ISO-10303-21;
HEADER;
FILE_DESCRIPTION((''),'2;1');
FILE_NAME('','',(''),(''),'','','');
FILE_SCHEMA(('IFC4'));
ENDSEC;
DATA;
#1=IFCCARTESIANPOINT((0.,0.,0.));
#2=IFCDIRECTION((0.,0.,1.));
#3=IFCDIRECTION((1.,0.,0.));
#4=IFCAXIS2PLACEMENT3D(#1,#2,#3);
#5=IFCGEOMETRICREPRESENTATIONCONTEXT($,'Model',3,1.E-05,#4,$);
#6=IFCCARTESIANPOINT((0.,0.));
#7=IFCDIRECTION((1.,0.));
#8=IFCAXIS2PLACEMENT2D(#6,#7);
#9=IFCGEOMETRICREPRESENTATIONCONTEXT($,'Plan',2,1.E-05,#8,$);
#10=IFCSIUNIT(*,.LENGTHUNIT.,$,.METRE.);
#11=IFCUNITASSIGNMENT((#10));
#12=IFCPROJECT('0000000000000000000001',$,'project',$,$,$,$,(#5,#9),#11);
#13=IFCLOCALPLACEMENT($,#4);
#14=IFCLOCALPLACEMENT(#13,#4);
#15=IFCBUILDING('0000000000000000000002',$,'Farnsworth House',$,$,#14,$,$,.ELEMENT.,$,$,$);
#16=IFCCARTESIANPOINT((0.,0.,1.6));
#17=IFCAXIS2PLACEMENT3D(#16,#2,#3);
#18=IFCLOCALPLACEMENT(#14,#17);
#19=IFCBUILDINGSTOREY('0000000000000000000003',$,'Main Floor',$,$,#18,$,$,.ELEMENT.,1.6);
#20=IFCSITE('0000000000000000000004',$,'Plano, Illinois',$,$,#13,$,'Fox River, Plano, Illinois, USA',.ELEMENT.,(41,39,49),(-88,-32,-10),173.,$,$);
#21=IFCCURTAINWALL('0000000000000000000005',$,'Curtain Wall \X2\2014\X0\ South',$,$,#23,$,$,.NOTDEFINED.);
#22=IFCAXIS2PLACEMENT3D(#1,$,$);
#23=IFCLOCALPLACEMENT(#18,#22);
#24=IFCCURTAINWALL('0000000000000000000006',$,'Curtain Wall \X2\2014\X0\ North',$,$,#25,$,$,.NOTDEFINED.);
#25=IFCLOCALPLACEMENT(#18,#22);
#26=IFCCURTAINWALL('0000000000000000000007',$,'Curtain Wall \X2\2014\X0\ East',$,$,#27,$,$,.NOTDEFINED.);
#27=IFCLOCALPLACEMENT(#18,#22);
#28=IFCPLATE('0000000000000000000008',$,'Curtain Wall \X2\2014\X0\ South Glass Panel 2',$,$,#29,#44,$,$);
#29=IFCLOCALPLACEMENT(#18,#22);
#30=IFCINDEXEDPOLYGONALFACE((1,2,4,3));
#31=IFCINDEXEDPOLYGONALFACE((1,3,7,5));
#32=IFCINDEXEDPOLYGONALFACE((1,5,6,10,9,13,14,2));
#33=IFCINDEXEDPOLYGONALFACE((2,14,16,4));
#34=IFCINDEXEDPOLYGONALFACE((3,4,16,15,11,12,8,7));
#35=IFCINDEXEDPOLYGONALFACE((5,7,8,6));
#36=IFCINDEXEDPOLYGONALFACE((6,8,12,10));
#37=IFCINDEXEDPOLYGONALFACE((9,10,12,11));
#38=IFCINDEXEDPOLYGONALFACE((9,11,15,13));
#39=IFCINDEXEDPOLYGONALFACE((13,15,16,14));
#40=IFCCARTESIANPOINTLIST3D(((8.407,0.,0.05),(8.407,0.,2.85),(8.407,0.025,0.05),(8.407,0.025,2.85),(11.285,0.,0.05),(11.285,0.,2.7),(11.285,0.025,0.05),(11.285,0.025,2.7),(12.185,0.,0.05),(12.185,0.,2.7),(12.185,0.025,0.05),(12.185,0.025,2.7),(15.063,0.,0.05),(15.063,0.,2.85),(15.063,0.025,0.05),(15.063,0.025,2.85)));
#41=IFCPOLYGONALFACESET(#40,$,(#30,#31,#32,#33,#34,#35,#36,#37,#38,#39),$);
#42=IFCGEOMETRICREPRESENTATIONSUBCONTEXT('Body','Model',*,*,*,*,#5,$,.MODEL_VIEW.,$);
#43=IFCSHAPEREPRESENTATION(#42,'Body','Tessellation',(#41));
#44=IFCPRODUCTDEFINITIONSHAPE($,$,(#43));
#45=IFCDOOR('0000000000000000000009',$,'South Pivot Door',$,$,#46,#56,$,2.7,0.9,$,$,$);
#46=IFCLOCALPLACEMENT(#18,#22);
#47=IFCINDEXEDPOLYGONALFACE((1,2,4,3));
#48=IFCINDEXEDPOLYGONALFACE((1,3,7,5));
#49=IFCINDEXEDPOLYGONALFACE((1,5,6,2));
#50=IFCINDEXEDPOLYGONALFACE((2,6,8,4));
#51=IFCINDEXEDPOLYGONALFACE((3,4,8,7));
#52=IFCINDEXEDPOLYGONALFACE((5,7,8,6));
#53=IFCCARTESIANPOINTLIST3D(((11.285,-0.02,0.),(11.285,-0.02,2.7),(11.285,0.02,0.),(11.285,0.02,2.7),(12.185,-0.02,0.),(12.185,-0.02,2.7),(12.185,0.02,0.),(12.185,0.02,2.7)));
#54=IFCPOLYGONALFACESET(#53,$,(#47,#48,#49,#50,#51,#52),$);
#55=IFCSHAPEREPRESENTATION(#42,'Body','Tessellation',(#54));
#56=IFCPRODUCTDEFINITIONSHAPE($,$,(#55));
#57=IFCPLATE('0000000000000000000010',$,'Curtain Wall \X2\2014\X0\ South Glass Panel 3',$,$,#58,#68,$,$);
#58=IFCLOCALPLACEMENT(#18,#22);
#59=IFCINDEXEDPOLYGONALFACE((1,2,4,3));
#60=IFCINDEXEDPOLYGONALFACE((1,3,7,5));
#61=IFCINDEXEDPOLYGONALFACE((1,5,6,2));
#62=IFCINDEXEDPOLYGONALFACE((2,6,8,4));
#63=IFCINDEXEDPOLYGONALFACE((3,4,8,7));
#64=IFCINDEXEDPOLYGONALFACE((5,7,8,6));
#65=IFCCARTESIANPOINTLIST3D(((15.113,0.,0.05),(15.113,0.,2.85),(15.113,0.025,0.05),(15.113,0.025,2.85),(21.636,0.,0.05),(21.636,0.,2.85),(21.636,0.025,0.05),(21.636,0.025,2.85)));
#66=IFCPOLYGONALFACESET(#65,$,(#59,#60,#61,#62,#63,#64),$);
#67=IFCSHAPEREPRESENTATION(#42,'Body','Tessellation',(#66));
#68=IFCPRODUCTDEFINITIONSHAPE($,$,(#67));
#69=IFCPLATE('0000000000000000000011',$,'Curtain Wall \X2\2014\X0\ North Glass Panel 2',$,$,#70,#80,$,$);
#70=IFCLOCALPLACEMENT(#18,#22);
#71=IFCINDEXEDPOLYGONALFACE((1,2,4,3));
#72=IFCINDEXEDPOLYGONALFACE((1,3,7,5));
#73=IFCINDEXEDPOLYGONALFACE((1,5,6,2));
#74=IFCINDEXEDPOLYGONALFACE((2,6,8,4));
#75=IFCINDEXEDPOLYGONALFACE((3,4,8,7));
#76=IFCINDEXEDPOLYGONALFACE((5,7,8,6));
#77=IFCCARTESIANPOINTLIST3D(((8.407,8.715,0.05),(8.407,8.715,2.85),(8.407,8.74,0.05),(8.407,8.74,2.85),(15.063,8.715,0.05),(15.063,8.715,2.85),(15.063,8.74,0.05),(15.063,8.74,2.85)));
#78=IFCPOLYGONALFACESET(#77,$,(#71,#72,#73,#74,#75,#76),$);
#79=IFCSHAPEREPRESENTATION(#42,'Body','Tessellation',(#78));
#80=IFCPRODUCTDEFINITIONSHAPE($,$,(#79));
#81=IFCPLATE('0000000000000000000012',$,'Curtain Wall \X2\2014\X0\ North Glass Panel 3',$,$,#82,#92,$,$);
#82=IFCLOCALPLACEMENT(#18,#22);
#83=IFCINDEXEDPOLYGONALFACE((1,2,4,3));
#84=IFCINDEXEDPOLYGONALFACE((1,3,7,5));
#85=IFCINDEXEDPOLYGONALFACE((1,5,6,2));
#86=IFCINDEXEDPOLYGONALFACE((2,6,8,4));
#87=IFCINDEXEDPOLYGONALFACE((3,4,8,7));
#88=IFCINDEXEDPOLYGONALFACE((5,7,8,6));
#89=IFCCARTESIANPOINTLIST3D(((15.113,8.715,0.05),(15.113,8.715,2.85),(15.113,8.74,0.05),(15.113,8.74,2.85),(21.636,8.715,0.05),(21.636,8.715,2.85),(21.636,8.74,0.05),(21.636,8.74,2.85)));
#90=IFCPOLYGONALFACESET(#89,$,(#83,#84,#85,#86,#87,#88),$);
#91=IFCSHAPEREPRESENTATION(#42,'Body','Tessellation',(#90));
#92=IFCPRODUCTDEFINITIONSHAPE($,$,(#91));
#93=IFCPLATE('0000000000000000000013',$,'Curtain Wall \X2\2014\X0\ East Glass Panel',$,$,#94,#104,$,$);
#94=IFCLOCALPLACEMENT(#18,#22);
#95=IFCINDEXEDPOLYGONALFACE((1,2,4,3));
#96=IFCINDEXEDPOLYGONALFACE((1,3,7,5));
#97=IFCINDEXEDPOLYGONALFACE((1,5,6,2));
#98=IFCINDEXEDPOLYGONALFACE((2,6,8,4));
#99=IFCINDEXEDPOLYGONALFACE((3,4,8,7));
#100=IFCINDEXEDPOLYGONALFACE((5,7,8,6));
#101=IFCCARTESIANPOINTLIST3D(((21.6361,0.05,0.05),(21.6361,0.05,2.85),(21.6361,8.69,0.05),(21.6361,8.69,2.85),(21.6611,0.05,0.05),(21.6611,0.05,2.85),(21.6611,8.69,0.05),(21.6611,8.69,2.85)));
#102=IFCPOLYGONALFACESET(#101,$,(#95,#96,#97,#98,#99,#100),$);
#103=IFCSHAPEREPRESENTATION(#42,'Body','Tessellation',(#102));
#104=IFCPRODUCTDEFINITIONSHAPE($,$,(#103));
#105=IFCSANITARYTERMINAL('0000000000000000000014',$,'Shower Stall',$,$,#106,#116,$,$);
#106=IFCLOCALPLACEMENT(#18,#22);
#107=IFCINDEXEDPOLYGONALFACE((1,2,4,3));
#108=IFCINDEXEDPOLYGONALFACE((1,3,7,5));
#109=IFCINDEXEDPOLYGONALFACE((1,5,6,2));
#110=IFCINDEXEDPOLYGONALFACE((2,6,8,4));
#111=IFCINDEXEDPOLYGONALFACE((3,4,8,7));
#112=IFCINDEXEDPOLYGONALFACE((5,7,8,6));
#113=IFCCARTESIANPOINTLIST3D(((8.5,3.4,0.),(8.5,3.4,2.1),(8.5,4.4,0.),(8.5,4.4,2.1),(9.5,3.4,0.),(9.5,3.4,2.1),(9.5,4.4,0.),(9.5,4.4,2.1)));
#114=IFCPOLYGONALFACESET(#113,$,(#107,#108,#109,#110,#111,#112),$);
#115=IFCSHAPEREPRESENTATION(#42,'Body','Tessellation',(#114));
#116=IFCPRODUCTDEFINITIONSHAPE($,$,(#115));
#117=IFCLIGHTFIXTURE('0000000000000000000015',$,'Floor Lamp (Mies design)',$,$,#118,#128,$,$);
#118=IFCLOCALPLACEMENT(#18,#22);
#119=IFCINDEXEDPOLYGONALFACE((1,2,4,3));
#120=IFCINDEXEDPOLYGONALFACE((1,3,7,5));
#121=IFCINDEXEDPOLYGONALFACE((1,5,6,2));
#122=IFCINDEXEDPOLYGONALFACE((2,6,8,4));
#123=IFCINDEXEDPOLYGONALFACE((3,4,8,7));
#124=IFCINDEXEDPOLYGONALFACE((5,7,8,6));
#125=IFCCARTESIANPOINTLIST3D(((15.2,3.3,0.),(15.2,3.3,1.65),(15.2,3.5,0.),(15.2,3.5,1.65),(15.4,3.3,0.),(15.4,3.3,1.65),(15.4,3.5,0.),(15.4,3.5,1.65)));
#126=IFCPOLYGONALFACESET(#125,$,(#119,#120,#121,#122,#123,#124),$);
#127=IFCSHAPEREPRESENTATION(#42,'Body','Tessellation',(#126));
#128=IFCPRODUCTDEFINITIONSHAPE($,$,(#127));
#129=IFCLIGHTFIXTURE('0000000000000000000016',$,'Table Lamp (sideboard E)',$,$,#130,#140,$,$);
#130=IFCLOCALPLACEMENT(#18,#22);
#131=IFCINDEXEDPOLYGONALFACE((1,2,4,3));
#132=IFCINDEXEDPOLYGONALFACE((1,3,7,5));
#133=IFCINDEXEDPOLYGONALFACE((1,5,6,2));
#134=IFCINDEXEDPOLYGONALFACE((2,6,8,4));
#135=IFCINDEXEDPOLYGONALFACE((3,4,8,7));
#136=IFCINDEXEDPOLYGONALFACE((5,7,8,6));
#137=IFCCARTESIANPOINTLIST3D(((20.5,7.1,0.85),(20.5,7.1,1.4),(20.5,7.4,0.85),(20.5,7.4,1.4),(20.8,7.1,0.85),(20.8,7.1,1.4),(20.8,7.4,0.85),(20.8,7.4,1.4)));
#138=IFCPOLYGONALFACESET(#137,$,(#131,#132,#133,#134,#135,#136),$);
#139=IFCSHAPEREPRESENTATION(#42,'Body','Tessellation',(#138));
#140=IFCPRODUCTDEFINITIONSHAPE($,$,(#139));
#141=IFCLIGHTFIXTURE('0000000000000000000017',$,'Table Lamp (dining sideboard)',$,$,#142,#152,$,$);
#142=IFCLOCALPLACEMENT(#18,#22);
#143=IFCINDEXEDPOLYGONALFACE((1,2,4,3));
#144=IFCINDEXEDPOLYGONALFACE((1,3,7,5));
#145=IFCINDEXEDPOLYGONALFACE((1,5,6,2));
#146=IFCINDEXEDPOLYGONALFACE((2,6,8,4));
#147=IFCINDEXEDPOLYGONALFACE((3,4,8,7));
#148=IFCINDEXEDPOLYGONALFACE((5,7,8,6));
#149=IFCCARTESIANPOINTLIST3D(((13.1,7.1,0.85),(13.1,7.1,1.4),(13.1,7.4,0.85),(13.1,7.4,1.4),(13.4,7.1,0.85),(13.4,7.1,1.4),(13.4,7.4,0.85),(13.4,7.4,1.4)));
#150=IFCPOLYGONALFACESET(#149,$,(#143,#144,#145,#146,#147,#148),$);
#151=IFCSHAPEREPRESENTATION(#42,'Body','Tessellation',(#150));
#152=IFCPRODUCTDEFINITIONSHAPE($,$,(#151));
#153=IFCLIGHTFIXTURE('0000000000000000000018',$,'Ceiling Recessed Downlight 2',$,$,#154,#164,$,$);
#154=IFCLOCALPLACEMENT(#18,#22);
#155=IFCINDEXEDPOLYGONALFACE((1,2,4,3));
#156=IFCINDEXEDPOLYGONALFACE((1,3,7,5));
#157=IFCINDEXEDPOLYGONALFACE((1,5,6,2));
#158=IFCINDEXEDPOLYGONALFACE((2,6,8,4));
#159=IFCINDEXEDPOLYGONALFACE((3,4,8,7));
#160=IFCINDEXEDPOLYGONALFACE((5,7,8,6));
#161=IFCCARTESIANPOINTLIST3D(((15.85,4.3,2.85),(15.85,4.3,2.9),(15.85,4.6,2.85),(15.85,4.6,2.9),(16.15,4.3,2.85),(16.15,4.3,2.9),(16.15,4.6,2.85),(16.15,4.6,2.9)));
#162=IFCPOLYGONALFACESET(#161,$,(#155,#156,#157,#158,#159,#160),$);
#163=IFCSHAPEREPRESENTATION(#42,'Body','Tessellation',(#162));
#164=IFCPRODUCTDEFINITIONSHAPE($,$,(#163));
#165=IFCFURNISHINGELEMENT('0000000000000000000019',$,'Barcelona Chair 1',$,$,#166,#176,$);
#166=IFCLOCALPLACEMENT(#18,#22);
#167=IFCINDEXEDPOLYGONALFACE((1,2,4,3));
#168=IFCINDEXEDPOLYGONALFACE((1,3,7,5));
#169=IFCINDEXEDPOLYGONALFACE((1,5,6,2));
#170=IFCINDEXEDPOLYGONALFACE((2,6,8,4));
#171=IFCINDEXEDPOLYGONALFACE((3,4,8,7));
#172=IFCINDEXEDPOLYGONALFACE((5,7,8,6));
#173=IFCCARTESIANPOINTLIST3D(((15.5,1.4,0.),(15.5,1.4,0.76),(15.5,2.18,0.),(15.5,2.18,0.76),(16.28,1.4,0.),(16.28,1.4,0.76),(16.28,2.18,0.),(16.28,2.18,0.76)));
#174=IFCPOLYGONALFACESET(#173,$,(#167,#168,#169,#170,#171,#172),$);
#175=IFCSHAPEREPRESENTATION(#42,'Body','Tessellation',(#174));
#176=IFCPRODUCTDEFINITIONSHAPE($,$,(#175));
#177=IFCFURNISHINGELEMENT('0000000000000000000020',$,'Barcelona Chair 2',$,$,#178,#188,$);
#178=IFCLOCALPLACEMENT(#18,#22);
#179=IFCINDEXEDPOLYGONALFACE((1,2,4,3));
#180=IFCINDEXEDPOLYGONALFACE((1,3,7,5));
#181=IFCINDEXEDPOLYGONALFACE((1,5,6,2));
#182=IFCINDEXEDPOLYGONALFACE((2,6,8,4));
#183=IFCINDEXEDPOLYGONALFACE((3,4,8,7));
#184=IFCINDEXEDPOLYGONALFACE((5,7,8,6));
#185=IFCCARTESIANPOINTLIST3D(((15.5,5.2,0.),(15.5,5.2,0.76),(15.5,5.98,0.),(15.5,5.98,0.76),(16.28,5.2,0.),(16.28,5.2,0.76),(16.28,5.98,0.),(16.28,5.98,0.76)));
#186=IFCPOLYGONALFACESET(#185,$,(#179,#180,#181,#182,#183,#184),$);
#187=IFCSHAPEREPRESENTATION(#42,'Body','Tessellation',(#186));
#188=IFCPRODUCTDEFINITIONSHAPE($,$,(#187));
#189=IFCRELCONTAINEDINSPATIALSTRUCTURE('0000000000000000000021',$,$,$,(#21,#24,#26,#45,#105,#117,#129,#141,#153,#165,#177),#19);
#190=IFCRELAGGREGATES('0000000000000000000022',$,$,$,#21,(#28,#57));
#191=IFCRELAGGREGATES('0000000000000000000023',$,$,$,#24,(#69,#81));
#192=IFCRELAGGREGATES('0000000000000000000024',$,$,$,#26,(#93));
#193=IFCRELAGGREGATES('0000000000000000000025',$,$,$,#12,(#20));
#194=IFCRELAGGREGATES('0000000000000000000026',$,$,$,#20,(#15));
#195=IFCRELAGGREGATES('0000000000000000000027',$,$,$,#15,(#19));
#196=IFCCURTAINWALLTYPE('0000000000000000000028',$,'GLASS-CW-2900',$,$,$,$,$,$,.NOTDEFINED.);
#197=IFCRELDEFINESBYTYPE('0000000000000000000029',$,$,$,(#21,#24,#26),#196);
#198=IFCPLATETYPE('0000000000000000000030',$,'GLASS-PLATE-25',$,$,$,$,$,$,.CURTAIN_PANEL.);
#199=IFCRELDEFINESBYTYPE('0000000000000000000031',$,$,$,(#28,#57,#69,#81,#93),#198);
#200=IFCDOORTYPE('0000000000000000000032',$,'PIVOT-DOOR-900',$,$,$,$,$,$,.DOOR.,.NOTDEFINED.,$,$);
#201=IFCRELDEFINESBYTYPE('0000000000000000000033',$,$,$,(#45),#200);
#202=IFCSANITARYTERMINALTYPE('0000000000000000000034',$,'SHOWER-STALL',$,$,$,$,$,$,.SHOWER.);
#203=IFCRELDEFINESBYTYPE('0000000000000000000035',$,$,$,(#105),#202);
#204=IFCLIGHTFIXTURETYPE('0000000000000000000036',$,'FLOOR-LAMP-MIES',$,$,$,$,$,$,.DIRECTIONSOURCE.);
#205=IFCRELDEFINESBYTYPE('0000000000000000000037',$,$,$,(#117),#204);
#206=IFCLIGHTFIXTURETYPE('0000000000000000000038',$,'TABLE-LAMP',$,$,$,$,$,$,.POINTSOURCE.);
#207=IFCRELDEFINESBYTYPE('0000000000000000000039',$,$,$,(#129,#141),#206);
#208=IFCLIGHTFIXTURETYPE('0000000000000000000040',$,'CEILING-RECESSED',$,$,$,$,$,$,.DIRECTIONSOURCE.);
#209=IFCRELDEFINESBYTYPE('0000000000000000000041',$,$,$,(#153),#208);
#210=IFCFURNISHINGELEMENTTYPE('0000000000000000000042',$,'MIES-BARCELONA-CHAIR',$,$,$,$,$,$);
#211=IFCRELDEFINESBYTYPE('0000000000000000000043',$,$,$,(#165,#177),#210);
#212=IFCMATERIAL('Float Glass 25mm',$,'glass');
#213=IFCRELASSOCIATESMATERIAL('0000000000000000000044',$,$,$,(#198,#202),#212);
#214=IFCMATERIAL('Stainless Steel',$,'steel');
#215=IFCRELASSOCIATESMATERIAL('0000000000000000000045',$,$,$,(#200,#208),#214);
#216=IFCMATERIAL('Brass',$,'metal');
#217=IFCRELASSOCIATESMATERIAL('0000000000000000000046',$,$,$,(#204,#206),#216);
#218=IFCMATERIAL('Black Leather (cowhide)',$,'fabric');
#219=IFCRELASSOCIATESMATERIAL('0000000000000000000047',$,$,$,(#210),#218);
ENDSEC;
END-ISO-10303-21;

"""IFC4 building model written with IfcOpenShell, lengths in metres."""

from ifc_helpers import new_model, si_unit, frame, origin_with_axes, origin_2d_with_axis, place, context, subcontext, project, spatial, rectangle, extrude, material, type_object, element, fill, aggregate, save


model = new_model("IFC4")

# Units and contexts
model_context = context("Model", 3, precision=1e-05, world=origin_with_axes())
plan_context = context("Plan", 2, precision=1e-05, world=origin_2d_with_axis())
body_context = subcontext(model_context, "Body", "Model", "MODEL_VIEW")
ifc_project = project(units=[si_unit("LENGTHUNIT", "METRE")], contexts=[model_context, plan_context])

# Site, building, storey
site_placement = place(None, origin_with_axes())
site = spatial("IfcSite", under=ifc_project, at=site_placement, Name="Plano, Illinois", LongName="Fox River, Plano, Illinois, USA", CompositionType="ELEMENT", RefLatitude=(41, 39, 49), RefLongitude=(-88, -32, -10), RefElevation=173.0)
building_placement = place(site_placement, origin_with_axes())
building = spatial("IfcBuilding", under=site, at=building_placement, Name="Farnsworth House", CompositionType="ELEMENT")
storey_placement = place(building_placement, frame((0.0, 0.0, 1.6), z_axis=(0.0, 0.0, 1.0), x_axis=(1.0, 0.0, 0.0)))
storey = spatial("IfcBuildingStorey", under=building, at=storey_placement, Name="Main Floor", CompositionType="ELEMENT", Elevation=1.6)

# Curtain walls
curtain_wall_type = type_object("IfcCurtainWallType", Name="GLASS-CW-2900", PredefinedType="NOTDEFINED")
curtain_wall_1_placement = place(storey_placement, frame((1.7839, 0.0, 0.0), z_axis=(0.0, 0.0, 1.0), x_axis=(1.0, 0.0, 0.0)))
curtain_wall_1 = element("IfcCurtainWall", 1, at=curtain_wall_1_placement, inside=storey, type_object=curtain_wall_type, Name="Curtain Wall — South", PredefinedType="NOTDEFINED")
ifc_material_1 = material(Name="Stainless Steel", Category="steel")
curtain_wall_2_placement = place(storey_placement, frame((1.7839, 8.715, 0.0), z_axis=(0.0, 0.0, 1.0), x_axis=(1.0, 0.0, 0.0)))
curtain_wall_2 = element("IfcCurtainWall", 2, at=curtain_wall_2_placement, inside=storey, type_object=curtain_wall_type, Name="Curtain Wall — North", PredefinedType="NOTDEFINED")
curtain_wall_3_placement = place(storey_placement, frame((21.6611, 0.0, 0.0), z_axis=(0.0, 0.0, 1.0), x_axis=(0.0, 1.0, 0.0)))
curtain_wall_3 = element("IfcCurtainWall", 3, at=curtain_wall_3_placement, inside=storey, type_object=curtain_wall_type, Name="Curtain Wall — East", PredefinedType="NOTDEFINED")

# Plate, opening, door
ifc_material_2 = material(Name="Float Glass 25mm", Category="glass")
plate_type = type_object("IfcPlateType", Name="GLASS-PLATE-25", PredefinedType="CURTAIN_PANEL", material=ifc_material_2)
plate_1_placement = place(curtain_wall_1_placement, frame((6.6231, 0.0, 0.05), z_axis=(0.0, 0.0, 1.0), x_axis=(1.0, 0.0, 0.0)))
plate_1 = element("IfcPlate", 4, at=plate_1_placement, type_object=plate_type, Name="Curtain Wall — South Glass Panel 2", context=body_context, shape_type="SweptSolid", body=[
    extrude(rectangle(XDim=6.656, YDim=0.025, at=origin_2d_with_axis()), frame((3.328, 0.0125, 0.0), z_axis=(0.0, 0.0, 1.0), x_axis=(1.0, 0.0, 0.0)), (0.0, 0.0, 1.0), 2.8),
])
opening_placement = place(curtain_wall_1_placement, frame((9.501, -0.025, 0.0), z_axis=(0.0, 0.0, 1.0), x_axis=(1.0, 0.0, 0.0)))
opening = element("IfcOpeningElement", 5, at=opening_placement, cuts=plate_1, PredefinedType="OPENING", context=body_context, shape_type="SweptSolid", body=[
    extrude(rectangle(XDim=0.9, YDim=0.075, at=origin_2d_with_axis()), frame((0.45, 0.0375, 0.0), z_axis=(0.0, 0.0, 1.0), x_axis=(1.0, 0.0, 0.0)), (0.0, 0.0, 1.0), 2.7),
])
door_type = type_object("IfcDoorType", Name="PIVOT-DOOR-900", OperationType="NOTDEFINED", PredefinedType="DOOR", material=ifc_material_1)
door_placement = place(storey_placement, frame((11.285, -0.02, 0.0), z_axis=(0.0, 0.0, 1.0), x_axis=(1.0, 0.0, 0.0)))
door = element("IfcDoor", 6, at=door_placement, inside=storey, type_object=door_type, Name="South Pivot Door", OverallHeight=2.7, OverallWidth=0.9, context=body_context, shape_type="SweptSolid", body=[
    extrude(rectangle(XDim=0.9, YDim=0.04, at=origin_2d_with_axis()), frame((0.45, 0.02, 0.0), z_axis=(0.0, 0.0, 1.0), x_axis=(1.0, 0.0, 0.0)), (0.0, 0.0, 1.0), 2.7),
])
fill(opening, door)

# Plates
plate_2_placement = place(curtain_wall_1_placement, frame((13.329, 0.0, 0.05), z_axis=(0.0, 0.0, 1.0), x_axis=(1.0, 0.0, 0.0)))
plate_2 = element("IfcPlate", 7, at=plate_2_placement, type_object=plate_type, Name="Curtain Wall — South Glass Panel 3", context=body_context, shape_type="SweptSolid", body=[
    extrude(rectangle(XDim=6.523, YDim=0.025, at=origin_2d_with_axis()), frame((3.2615, 0.0125, 0.0), z_axis=(0.0, 0.0, 1.0), x_axis=(1.0, 0.0, 0.0)), (0.0, 0.0, 1.0), 2.8),
])
aggregate(curtain_wall_1, [plate_1, plate_2])
plate_3_placement = place(curtain_wall_2_placement, frame((6.6231, 0.0, 0.05), z_axis=(0.0, 0.0, 1.0), x_axis=(1.0, 0.0, 0.0)))
plate_3 = element("IfcPlate", 8, at=plate_3_placement, type_object=plate_type, Name="Curtain Wall — North Glass Panel 2", context=body_context, shape_type="SweptSolid", body=[
    extrude(rectangle(XDim=6.656, YDim=0.025, at=origin_2d_with_axis()), frame((3.328, 0.0125, 0.0), z_axis=(0.0, 0.0, 1.0), x_axis=(1.0, 0.0, 0.0)), (0.0, 0.0, 1.0), 2.8),
])
plate_4_placement = place(curtain_wall_2_placement, frame((13.329, 0.0, 0.05), z_axis=(0.0, 0.0, 1.0), x_axis=(1.0, 0.0, 0.0)))
plate_4 = element("IfcPlate", 9, at=plate_4_placement, type_object=plate_type, Name="Curtain Wall — North Glass Panel 3", context=body_context, shape_type="SweptSolid", body=[
    extrude(rectangle(XDim=6.523, YDim=0.025, at=origin_2d_with_axis()), frame((3.2615, 0.0125, 0.0), z_axis=(0.0, 0.0, 1.0), x_axis=(1.0, 0.0, 0.0)), (0.0, 0.0, 1.0), 2.8),
])
aggregate(curtain_wall_2, [plate_3, plate_4])
plate_5_placement = place(curtain_wall_3_placement, frame((0.05, 0.0, 0.05), z_axis=(0.0, 0.0, 1.0), x_axis=(1.0, 0.0, 0.0)))
plate_5 = element("IfcPlate", 10, at=plate_5_placement, type_object=plate_type, Name="Curtain Wall — East Glass Panel", context=body_context, shape_type="SweptSolid", body=[
    extrude(rectangle(XDim=8.64, YDim=0.025, at=origin_2d_with_axis()), frame((4.32, 0.0125, 0.0), z_axis=(0.0, 0.0, 1.0), x_axis=(1.0, 0.0, 0.0)), (0.0, 0.0, 1.0), 2.8),
])
aggregate(curtain_wall_3, [plate_5])

# Sanitary terminal
sanitary_terminal_type = type_object("IfcSanitaryTerminalType", Name="SHOWER-STALL", PredefinedType="SHOWER", material=ifc_material_2)
sanitary_terminal_placement = place(storey_placement, frame((8.5, 3.4, 0.0), z_axis=(0.0, 0.0, 1.0), x_axis=(1.0, 0.0, 0.0)))
element("IfcSanitaryTerminal", 11, at=sanitary_terminal_placement, inside=storey, type_object=sanitary_terminal_type, Name="Shower Stall", context=body_context, shape_type="SweptSolid", body=[
    extrude(rectangle(XDim=1.0, YDim=1.0, at=origin_2d_with_axis()), frame((0.5, 0.5, 0.0), z_axis=(0.0, 0.0, 1.0), x_axis=(1.0, 0.0, 0.0)), (0.0, 0.0, 1.0), 2.1),
])

# Light fixtures
ifc_material_3 = material(Name="Brass", Category="metal")
light_fixture_type_1 = type_object("IfcLightFixtureType", Name="FLOOR-LAMP-MIES", PredefinedType="DIRECTIONSOURCE", material=ifc_material_3)
light_fixture_1_placement = place(storey_placement, frame((15.2, 3.3, 0.0), z_axis=(0.0, 0.0, 1.0), x_axis=(1.0, 0.0, 0.0)))
element("IfcLightFixture", 12, at=light_fixture_1_placement, inside=storey, type_object=light_fixture_type_1, Name="Floor Lamp (Mies design)", context=body_context, shape_type="SweptSolid", body=[
    extrude(rectangle(XDim=0.2, YDim=0.2, at=origin_2d_with_axis()), frame((0.1, 0.1, 0.0), z_axis=(0.0, 0.0, 1.0), x_axis=(1.0, 0.0, 0.0)), (0.0, 0.0, 1.0), 1.65),
])
light_fixture_type_2 = type_object("IfcLightFixtureType", Name="TABLE-LAMP", PredefinedType="POINTSOURCE", material=ifc_material_3)
for number, where, z_axis, x_axis, name in (
    (13, (20.5, 7.1, 0.85), (0.0, 0.0, 1.0), (1.0, 0.0, 0.0), "Table Lamp (sideboard E)"),
    (14, (13.1, 7.1, 0.85), (0.0, 0.0, 1.0), (1.0, 0.0, 0.0), "Table Lamp (dining sideboard)"),
):
    element("IfcLightFixture", number, at=place(storey_placement, frame(where, z_axis=z_axis, x_axis=x_axis)), inside=storey, type_object=light_fixture_type_2, Name=name, context=body_context, shape_type="SweptSolid", body=[
        extrude(rectangle(XDim=0.3, YDim=0.3, at=origin_2d_with_axis()), frame((0.15, 0.15, 0.0), z_axis=(0.0, 0.0, 1.0), x_axis=(1.0, 0.0, 0.0)), (0.0, 0.0, 1.0), 0.55),
    ])
light_fixture_type_3 = type_object("IfcLightFixtureType", Name="CEILING-RECESSED", PredefinedType="DIRECTIONSOURCE", material=ifc_material_1)
light_fixture_2_placement = place(storey_placement, frame((15.85, 4.3, 2.85), z_axis=(0.0, 0.0, 1.0), x_axis=(1.0, 0.0, 0.0)))
element("IfcLightFixture", 15, at=light_fixture_2_placement, inside=storey, type_object=light_fixture_type_3, Name="Ceiling Recessed Downlight 2", context=body_context, shape_type="SweptSolid", body=[
    extrude(rectangle(XDim=0.3, YDim=0.3, at=origin_2d_with_axis()), frame((0.15, 0.15, 0.0), z_axis=(0.0, 0.0, 1.0), x_axis=(1.0, 0.0, 0.0)), (0.0, 0.0, 1.0), 0.05),
])

# Furnishing elements
ifc_material_4 = material(Name="Black Leather (cowhide)", Category="fabric")
furnishing_element_type_1 = type_object("IfcFurnishingElementType", Name="MIES-BARCELONA-CHAIR", material=ifc_material_4)
for number, where, z_axis, x_axis, name in (
    (16, (15.5, 1.4, 0.0), (0.0, 0.0, 1.0), (1.0, 0.0, 0.0), "Barcelona Chair 1"),
    (17, (15.5, 5.2, 0.0), (0.0, 0.0, 1.0), (1.0, 0.0, 0.0), "Barcelona Chair 2"),
):
    element("IfcFurnishingElement", number, at=place(storey_placement, frame(where, z_axis=z_axis, x_axis=x_axis)), inside=storey, type_object=furnishing_element_type_1, Name=name, context=body_context, shape_type="SweptSolid", body=[
        extrude(rectangle(XDim=0.78, YDim=0.78, at=origin_2d_with_axis()), frame((0.39, 0.39, 0.0), z_axis=(0.0, 0.0, 1.0), x_axis=(1.0, 0.0, 0.0)), (0.0, 0.0, 1.0), 0.76),
    ])

save(model, "model.ifc")
